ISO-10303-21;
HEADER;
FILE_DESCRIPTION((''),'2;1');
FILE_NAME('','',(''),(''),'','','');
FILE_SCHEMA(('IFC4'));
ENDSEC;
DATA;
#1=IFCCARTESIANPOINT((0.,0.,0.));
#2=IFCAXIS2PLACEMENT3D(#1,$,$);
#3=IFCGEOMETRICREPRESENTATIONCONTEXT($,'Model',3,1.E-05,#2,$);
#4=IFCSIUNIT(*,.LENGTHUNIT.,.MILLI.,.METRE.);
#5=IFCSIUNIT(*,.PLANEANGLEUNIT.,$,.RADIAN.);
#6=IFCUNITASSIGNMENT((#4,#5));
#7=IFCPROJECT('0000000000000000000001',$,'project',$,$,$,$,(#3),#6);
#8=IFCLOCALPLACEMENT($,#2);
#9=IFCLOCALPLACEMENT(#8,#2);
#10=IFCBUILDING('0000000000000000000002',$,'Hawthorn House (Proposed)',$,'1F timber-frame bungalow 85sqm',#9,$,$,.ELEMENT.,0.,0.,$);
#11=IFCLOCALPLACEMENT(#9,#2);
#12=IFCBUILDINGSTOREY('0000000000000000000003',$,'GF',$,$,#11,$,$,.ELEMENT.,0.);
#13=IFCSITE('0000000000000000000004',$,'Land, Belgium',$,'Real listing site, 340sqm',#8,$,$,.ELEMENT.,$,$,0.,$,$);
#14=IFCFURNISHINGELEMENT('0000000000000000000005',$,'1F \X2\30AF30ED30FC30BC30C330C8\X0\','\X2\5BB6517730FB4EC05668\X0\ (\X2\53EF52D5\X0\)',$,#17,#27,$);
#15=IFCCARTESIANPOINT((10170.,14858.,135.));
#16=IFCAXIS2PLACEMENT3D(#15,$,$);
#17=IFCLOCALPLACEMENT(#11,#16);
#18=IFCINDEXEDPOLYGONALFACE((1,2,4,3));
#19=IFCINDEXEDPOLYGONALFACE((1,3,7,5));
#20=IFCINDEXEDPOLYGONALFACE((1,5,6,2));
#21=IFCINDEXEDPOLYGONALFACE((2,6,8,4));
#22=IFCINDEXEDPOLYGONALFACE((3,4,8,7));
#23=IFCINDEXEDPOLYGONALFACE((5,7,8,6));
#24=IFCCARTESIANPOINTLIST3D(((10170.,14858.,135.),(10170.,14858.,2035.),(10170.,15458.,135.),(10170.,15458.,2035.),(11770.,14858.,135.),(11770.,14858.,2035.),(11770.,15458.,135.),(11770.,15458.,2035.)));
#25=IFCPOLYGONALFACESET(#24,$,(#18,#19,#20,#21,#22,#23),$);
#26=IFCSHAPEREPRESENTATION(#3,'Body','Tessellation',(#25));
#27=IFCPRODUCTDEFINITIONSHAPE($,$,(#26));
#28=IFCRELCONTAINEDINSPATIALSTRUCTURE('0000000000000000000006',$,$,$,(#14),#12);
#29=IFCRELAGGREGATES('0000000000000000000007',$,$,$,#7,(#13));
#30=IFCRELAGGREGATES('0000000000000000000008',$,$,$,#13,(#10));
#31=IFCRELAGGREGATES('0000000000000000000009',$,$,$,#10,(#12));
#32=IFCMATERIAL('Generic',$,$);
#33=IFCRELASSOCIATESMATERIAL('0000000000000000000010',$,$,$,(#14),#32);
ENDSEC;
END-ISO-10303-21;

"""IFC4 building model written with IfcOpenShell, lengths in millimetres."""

from ifc_helpers import new_model, si_unit, frame, frame_2d, origin, place, context, project, spatial, rectangle, extrude, material, element, save


model = new_model("IFC4")

# Units and contexts
model_context = context("Model", 3, precision=1e-05, world=origin())
ifc_project = project(units=[si_unit("LENGTHUNIT", "METRE", prefix="MILLI"), si_unit("PLANEANGLEUNIT", "RADIAN")], contexts=[model_context])

# Site, building, storey
site_placement = place(None, origin())
site = spatial("IfcSite", under=ifc_project, at=site_placement, Name="Land, Belgium", ObjectType="Real listing site, 340sqm", CompositionType="ELEMENT", RefElevation=0.0)
building_placement = place(site_placement, origin())
building = spatial("IfcBuilding", under=site, at=building_placement, Name="Hawthorn House (Proposed)", ObjectType="1F timber-frame bungalow 85sqm", CompositionType="ELEMENT", ElevationOfRefHeight=0.0, ElevationOfTerrain=0.0)
storey_placement = place(building_placement, origin())
storey = spatial("IfcBuildingStorey", under=building, at=storey_placement, Name="GF", CompositionType="ELEMENT", Elevation=0.0)

# Shared definitions
ifc_material_1 = material(Name="Generic")

# Furnishing element
furnishing_placement = place(storey_placement, frame((10170.0, 14858.0, 135.0)))
element("IfcFurnishingElement", 1, at=furnishing_placement, inside=storey, material=ifc_material_1, Name="1F クローゼット", Description="家具・什器 (可動)", context=model_context, shape_type="SweptSolid", body=[
    extrude(rectangle(XDim=1600.0, YDim=600.0, at=frame_2d((800.0, 300.0))), frame((10170.0, 14858.0, 135.0)), (0.0, 0.0, 1.0), 1900.0),
])

save(model, "model.ifc")
